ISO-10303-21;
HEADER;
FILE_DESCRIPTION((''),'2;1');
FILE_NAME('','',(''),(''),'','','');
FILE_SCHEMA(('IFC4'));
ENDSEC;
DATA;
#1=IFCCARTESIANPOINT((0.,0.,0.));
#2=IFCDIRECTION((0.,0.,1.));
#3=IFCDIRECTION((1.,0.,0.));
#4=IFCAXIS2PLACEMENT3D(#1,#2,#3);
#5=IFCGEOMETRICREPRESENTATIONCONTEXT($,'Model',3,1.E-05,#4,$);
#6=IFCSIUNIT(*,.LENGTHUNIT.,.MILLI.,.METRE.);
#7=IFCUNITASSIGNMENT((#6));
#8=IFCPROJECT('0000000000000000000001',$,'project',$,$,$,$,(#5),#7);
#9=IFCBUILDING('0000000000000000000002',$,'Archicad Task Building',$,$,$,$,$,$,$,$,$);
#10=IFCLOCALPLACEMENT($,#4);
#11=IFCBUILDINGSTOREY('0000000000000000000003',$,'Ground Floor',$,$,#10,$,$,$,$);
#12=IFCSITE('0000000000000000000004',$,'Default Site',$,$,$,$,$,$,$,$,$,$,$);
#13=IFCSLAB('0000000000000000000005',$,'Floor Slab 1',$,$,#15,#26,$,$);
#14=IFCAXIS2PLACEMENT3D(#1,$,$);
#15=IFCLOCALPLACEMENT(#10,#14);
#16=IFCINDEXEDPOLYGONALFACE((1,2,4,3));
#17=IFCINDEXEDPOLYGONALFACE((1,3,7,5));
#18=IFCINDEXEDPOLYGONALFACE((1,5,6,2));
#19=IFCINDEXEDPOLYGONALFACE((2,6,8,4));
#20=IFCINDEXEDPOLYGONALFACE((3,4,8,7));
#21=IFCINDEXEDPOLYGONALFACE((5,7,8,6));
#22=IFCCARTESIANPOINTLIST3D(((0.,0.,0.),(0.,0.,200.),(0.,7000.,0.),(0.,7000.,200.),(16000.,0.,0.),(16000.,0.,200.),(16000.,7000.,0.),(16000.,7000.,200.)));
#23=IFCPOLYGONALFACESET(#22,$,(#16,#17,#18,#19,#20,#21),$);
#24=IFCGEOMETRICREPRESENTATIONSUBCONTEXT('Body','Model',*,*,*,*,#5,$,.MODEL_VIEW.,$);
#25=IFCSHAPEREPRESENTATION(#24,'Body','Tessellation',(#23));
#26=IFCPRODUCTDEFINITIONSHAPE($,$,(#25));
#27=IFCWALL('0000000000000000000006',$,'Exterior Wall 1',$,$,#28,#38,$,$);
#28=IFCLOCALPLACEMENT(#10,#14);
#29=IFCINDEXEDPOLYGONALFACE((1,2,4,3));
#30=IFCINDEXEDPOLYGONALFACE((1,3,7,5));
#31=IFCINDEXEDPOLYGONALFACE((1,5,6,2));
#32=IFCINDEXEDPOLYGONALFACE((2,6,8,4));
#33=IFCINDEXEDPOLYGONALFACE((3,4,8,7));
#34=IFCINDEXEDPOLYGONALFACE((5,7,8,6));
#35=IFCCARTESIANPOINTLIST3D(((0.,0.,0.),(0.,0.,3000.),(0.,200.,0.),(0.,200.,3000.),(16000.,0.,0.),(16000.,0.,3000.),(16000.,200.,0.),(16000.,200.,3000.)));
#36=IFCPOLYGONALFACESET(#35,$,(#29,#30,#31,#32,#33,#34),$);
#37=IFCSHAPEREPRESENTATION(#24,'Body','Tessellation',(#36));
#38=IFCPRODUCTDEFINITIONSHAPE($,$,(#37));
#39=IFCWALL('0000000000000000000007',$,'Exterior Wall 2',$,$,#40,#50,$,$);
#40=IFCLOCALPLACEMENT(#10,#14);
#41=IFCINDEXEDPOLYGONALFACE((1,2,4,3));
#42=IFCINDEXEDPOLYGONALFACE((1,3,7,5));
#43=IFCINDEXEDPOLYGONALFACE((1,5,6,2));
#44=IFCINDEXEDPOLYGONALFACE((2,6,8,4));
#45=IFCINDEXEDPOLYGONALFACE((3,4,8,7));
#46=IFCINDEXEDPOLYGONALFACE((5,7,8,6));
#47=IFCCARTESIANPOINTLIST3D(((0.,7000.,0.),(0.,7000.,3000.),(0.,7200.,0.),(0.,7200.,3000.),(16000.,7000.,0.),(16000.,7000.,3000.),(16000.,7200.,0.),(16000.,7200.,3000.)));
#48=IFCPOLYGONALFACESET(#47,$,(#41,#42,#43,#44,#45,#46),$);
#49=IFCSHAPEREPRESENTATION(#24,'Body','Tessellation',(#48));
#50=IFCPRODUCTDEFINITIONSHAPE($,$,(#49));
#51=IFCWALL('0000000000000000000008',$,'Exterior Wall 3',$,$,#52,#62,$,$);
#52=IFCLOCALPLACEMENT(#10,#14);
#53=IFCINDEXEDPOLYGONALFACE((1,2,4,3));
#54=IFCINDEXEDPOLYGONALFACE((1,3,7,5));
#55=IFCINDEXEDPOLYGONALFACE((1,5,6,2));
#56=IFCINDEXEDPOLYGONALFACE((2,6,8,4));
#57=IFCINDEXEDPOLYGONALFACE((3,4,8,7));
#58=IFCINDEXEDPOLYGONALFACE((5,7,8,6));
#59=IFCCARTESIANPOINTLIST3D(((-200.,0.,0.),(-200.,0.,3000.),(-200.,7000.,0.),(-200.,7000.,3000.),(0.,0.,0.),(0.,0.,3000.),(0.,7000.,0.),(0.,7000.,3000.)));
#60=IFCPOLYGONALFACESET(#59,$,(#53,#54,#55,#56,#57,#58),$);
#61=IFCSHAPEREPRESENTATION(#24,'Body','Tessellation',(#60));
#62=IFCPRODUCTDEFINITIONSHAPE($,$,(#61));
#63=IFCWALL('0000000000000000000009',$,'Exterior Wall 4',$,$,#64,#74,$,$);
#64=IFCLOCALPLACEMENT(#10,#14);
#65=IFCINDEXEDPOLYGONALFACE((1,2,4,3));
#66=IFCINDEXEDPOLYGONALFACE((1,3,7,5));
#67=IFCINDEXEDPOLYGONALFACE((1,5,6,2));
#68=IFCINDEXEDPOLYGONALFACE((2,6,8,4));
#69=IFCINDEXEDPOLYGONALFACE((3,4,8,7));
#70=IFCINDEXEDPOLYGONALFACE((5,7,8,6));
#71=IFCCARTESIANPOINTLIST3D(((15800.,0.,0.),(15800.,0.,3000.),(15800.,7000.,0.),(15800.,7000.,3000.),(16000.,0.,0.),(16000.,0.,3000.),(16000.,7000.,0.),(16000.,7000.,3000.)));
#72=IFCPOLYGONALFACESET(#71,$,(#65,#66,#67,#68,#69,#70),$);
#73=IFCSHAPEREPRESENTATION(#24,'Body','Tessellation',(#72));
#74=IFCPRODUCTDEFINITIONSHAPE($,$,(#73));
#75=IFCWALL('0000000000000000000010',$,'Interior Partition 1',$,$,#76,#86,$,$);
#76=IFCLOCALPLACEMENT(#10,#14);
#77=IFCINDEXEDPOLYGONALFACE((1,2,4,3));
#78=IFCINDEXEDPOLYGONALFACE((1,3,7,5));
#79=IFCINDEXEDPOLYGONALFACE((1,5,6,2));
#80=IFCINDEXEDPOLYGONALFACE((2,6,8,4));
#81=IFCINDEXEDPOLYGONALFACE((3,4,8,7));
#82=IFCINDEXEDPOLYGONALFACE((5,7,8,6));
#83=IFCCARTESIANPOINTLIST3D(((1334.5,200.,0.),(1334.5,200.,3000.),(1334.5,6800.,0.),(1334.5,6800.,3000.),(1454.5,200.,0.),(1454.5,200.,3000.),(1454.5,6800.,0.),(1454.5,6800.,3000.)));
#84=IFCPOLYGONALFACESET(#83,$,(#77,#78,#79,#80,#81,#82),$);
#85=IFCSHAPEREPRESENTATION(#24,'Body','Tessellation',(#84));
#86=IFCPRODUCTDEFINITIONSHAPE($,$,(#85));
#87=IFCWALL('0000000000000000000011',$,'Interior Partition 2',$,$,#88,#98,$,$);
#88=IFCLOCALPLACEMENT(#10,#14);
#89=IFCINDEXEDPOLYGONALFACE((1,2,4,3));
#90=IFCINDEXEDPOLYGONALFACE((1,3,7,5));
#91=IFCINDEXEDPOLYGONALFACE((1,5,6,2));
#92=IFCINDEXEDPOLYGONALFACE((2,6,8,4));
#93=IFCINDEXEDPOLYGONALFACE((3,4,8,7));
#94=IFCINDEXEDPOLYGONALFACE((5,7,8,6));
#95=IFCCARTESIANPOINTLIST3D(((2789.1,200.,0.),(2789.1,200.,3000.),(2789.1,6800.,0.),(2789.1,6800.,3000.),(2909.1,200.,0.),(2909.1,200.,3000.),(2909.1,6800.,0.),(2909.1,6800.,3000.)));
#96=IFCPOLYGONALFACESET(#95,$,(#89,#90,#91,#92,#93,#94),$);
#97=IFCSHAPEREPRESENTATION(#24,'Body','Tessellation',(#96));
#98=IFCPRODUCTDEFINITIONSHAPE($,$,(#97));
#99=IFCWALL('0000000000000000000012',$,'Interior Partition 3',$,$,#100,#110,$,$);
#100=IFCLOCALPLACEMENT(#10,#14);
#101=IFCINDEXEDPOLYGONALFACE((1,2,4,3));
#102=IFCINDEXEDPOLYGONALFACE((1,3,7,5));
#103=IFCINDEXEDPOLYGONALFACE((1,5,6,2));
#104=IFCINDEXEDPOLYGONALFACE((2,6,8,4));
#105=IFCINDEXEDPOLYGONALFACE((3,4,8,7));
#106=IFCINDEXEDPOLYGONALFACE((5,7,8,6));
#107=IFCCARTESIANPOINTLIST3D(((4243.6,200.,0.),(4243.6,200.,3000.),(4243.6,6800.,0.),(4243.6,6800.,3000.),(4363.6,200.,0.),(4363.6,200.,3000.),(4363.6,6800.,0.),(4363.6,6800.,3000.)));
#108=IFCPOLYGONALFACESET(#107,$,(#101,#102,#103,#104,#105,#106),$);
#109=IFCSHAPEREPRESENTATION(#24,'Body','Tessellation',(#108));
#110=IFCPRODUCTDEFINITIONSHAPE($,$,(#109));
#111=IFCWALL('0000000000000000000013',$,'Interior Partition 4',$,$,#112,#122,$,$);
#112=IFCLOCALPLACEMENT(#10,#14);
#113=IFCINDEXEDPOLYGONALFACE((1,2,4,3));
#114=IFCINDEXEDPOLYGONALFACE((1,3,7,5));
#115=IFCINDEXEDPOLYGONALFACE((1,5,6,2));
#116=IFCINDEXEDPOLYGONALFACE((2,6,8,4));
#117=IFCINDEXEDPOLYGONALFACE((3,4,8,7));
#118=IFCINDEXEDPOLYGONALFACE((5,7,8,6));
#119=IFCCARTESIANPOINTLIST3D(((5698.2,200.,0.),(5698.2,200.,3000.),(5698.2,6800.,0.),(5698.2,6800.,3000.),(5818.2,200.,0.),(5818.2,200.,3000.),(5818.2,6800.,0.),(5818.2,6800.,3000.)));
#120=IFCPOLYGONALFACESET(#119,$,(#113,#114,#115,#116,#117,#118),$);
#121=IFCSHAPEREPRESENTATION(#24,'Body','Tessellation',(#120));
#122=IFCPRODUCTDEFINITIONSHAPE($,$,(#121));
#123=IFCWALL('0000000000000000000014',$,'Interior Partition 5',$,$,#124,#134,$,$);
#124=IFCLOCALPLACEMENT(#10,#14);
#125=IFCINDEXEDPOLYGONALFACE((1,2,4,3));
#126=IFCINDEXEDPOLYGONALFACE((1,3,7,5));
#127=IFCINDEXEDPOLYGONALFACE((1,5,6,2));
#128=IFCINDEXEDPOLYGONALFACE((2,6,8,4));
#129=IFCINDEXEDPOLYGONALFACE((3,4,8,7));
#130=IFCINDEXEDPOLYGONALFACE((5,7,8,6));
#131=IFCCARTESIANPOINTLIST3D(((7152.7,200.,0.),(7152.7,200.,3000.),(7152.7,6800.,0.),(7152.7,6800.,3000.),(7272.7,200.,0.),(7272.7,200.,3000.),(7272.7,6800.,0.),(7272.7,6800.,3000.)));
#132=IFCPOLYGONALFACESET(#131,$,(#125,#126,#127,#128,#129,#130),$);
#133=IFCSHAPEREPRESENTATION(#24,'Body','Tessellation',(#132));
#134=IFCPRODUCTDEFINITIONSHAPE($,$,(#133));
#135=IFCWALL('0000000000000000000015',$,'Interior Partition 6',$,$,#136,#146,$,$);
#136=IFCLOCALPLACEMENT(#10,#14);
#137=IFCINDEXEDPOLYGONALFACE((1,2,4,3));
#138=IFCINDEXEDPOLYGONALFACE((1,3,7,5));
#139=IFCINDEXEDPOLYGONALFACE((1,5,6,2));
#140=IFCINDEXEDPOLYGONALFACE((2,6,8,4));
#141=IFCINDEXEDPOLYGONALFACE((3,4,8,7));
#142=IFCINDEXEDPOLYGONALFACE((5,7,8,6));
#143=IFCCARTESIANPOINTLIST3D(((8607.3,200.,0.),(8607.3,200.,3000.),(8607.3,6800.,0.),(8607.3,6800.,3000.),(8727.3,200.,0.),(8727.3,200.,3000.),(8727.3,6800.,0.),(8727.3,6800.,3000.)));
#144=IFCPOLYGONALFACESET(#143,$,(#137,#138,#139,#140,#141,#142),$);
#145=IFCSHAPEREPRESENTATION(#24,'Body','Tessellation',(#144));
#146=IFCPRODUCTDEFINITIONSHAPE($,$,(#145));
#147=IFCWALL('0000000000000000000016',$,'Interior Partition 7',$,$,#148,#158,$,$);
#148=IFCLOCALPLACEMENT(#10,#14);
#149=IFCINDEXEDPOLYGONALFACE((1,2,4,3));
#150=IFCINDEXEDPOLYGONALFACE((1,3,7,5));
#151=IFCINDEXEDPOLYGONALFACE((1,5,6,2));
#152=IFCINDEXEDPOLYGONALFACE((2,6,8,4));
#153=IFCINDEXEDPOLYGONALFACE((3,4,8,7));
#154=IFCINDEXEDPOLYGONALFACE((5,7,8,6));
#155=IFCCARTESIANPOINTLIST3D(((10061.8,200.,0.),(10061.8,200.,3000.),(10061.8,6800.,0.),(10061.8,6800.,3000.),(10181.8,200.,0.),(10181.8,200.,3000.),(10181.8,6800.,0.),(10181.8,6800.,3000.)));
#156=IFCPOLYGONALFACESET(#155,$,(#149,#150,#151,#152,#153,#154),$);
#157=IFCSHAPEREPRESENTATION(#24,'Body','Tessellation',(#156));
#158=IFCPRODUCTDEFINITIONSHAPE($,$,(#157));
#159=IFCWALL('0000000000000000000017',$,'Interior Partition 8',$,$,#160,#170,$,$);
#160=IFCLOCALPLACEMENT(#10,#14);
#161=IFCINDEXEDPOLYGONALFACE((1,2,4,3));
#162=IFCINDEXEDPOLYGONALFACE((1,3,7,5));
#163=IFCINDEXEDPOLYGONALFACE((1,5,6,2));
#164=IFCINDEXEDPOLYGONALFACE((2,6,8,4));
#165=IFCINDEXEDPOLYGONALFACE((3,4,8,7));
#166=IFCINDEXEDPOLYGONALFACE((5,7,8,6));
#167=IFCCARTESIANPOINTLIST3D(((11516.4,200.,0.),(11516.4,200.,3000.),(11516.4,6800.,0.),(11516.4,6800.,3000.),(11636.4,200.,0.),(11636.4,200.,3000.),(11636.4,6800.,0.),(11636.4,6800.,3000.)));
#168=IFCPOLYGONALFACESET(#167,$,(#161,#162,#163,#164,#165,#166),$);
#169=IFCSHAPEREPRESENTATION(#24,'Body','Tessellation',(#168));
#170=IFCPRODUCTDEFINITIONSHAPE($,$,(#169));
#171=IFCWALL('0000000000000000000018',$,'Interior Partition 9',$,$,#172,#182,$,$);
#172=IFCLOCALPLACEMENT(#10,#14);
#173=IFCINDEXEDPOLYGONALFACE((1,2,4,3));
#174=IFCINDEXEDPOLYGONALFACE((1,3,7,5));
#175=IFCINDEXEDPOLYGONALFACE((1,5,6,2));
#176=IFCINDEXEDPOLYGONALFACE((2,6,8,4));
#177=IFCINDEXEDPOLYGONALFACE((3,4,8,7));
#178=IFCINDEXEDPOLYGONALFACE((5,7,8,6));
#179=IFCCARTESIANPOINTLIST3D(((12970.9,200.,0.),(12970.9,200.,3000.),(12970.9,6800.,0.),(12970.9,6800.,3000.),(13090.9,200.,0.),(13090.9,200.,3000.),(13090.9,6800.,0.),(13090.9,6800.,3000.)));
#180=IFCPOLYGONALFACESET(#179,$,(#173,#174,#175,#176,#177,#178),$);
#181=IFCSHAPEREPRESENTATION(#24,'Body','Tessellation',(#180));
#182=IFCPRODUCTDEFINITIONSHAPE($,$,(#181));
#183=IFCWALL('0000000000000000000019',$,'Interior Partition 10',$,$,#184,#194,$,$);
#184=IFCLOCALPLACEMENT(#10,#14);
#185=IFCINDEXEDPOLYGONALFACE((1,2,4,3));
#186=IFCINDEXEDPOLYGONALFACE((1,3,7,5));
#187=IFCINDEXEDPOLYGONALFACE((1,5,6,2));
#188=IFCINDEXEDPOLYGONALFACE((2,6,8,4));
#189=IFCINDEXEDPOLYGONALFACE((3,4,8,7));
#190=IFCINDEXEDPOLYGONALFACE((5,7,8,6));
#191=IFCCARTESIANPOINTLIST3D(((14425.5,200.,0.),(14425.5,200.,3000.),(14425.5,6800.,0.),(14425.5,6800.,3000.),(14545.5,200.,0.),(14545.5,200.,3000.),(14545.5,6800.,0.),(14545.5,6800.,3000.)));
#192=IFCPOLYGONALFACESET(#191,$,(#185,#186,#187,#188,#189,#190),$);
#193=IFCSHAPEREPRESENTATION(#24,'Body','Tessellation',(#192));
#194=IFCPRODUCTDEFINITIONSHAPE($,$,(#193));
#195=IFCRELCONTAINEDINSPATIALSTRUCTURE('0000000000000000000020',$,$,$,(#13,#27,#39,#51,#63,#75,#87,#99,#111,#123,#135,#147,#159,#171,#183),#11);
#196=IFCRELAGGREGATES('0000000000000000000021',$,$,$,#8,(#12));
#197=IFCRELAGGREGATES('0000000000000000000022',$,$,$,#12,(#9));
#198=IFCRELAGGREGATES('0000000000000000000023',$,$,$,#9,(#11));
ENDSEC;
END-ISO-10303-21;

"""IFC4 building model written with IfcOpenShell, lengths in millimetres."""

from ifc_helpers import new_model, si_unit, frame, origin_with_axes, place, context, subcontext, project, spatial, indexed_curve, outline, extrude, element, save


model = new_model("IFC4")

# Units and contexts
model_context = context("Model", 3, precision=1e-05, world=origin_with_axes())
body_context = subcontext(model_context, "Body", "Model", "MODEL_VIEW")
ifc_project = project(units=[si_unit("LENGTHUNIT", "METRE", prefix="MILLI")], contexts=[model_context])

# Site, building, storey
site = spatial("IfcSite", under=ifc_project, Name="Default Site")
building = spatial("IfcBuilding", under=site, Name="Archicad Task Building")
storey_placement = place(None, origin_with_axes())
storey = spatial("IfcBuildingStorey", under=building, at=storey_placement, Name="Ground Floor")

# Slab
slab_placement = place(storey_placement, origin_with_axes())
element("IfcSlab", 1, at=slab_placement, inside=storey, Name="Floor Slab 1", context=body_context, shape_type="SweptSolid", body=[
    extrude(outline(indexed_curve([(0.0, 0.0), (16000.0, 0.0), (16000.0, 7000.0), (0.0, 7000.0), (0.0, 0.0)])), None, (0.0, 0.0, 1.0), 200.0),
])

# Walls
for number, where, z_axis, x_axis, name in (
    (2, (0.0, 0.0, 0.0), (0.0, 0.0, 1.0), (1.0, 0.0, 0.0), "Exterior Wall 1"),
    (3, (0.0, 7000.0, 0.0), (0.0, 0.0, 1.0), (1.0, 0.0, 0.0), "Exterior Wall 2"),
):
    element("IfcWall", number, at=place(storey_placement, frame(where, z_axis=z_axis, x_axis=x_axis)), inside=storey, Name=name, context=body_context, shape_type="SweptSolid", body=[
        extrude(outline(indexed_curve([(0.0, 0.0), (0.0, 200.0), (16000.0, 200.0), (16000.0, 0.0), (0.0, 0.0)], self_intersect=False)), origin_with_axes(), (0.0, 0.0, 1.0), 3000.0),
    ])
for number, where, z_axis, x_axis, name in (
    (4, (0.0, 0.0, 0.0), (0.0, 0.0, 1.0), (0.0, 1.0, 0.0), "Exterior Wall 3"),
    (5, (16000.0, 0.0, 0.0), (0.0, 0.0, 1.0), (0.0, 1.0, 0.0), "Exterior Wall 4"),
):
    element("IfcWall", number, at=place(storey_placement, frame(where, z_axis=z_axis, x_axis=x_axis)), inside=storey, Name=name, context=body_context, shape_type="SweptSolid", body=[
        extrude(outline(indexed_curve([(0.0, 0.0), (0.0, 200.0), (7000.0, 200.0), (7000.0, 0.0), (0.0, 0.0)], self_intersect=False)), origin_with_axes(), (0.0, 0.0, 1.0), 3000.0),
    ])
for number, where, z_axis, x_axis, name in (
    (6, (1454.5, 200.0, 0.0), (0.0, 0.0, 1.0), (0.0, 1.0, 0.0), "Interior Partition 1"),
    (7, (2909.1, 200.0, 0.0), (0.0, 0.0, 1.0), (0.0, 1.0, 0.0), "Interior Partition 2"),
    (8, (4363.6, 200.0, 0.0), (0.0, 0.0, 1.0), (0.0, 1.0, 0.0), "Interior Partition 3"),
    (9, (5818.2, 200.0, 0.0), (0.0, 0.0, 1.0), (0.0, 1.0, 0.0), "Interior Partition 4"),
    (10, (7272.7, 200.0, 0.0), (0.0, 0.0, 1.0), (0.0, 1.0, 0.0), "Interior Partition 5"),
    (11, (8727.3, 200.0, 0.0), (0.0, 0.0, 1.0), (0.0, 1.0, 0.0), "Interior Partition 6"),
    (12, (10181.8, 200.0, 0.0), (0.0, 0.0, 1.0), (0.0, 1.0, 0.0), "Interior Partition 7"),
    (13, (11636.4, 200.0, 0.0), (0.0, 0.0, 1.0), (0.0, 1.0, 0.0), "Interior Partition 8"),
    (14, (13090.9, 200.0, 0.0), (0.0, 0.0, 1.0), (0.0, 1.0, 0.0), "Interior Partition 9"),
    (15, (14545.5, 200.0, 0.0), (0.0, 0.0, 1.0), (0.0, 1.0, 0.0), "Interior Partition 10"),
):
    element("IfcWall", number, at=place(storey_placement, frame(where, z_axis=z_axis, x_axis=x_axis)), inside=storey, Name=name, context=body_context, shape_type="SweptSolid", body=[
        extrude(outline(indexed_curve([(0.0, 0.0), (0.0, 120.0), (6600.0, 120.0), (6600.0, 0.0), (0.0, 0.0)], self_intersect=False)), origin_with_axes(), (0.0, 0.0, 1.0), 3000.0),
    ])

save(model, "model.ifc")
